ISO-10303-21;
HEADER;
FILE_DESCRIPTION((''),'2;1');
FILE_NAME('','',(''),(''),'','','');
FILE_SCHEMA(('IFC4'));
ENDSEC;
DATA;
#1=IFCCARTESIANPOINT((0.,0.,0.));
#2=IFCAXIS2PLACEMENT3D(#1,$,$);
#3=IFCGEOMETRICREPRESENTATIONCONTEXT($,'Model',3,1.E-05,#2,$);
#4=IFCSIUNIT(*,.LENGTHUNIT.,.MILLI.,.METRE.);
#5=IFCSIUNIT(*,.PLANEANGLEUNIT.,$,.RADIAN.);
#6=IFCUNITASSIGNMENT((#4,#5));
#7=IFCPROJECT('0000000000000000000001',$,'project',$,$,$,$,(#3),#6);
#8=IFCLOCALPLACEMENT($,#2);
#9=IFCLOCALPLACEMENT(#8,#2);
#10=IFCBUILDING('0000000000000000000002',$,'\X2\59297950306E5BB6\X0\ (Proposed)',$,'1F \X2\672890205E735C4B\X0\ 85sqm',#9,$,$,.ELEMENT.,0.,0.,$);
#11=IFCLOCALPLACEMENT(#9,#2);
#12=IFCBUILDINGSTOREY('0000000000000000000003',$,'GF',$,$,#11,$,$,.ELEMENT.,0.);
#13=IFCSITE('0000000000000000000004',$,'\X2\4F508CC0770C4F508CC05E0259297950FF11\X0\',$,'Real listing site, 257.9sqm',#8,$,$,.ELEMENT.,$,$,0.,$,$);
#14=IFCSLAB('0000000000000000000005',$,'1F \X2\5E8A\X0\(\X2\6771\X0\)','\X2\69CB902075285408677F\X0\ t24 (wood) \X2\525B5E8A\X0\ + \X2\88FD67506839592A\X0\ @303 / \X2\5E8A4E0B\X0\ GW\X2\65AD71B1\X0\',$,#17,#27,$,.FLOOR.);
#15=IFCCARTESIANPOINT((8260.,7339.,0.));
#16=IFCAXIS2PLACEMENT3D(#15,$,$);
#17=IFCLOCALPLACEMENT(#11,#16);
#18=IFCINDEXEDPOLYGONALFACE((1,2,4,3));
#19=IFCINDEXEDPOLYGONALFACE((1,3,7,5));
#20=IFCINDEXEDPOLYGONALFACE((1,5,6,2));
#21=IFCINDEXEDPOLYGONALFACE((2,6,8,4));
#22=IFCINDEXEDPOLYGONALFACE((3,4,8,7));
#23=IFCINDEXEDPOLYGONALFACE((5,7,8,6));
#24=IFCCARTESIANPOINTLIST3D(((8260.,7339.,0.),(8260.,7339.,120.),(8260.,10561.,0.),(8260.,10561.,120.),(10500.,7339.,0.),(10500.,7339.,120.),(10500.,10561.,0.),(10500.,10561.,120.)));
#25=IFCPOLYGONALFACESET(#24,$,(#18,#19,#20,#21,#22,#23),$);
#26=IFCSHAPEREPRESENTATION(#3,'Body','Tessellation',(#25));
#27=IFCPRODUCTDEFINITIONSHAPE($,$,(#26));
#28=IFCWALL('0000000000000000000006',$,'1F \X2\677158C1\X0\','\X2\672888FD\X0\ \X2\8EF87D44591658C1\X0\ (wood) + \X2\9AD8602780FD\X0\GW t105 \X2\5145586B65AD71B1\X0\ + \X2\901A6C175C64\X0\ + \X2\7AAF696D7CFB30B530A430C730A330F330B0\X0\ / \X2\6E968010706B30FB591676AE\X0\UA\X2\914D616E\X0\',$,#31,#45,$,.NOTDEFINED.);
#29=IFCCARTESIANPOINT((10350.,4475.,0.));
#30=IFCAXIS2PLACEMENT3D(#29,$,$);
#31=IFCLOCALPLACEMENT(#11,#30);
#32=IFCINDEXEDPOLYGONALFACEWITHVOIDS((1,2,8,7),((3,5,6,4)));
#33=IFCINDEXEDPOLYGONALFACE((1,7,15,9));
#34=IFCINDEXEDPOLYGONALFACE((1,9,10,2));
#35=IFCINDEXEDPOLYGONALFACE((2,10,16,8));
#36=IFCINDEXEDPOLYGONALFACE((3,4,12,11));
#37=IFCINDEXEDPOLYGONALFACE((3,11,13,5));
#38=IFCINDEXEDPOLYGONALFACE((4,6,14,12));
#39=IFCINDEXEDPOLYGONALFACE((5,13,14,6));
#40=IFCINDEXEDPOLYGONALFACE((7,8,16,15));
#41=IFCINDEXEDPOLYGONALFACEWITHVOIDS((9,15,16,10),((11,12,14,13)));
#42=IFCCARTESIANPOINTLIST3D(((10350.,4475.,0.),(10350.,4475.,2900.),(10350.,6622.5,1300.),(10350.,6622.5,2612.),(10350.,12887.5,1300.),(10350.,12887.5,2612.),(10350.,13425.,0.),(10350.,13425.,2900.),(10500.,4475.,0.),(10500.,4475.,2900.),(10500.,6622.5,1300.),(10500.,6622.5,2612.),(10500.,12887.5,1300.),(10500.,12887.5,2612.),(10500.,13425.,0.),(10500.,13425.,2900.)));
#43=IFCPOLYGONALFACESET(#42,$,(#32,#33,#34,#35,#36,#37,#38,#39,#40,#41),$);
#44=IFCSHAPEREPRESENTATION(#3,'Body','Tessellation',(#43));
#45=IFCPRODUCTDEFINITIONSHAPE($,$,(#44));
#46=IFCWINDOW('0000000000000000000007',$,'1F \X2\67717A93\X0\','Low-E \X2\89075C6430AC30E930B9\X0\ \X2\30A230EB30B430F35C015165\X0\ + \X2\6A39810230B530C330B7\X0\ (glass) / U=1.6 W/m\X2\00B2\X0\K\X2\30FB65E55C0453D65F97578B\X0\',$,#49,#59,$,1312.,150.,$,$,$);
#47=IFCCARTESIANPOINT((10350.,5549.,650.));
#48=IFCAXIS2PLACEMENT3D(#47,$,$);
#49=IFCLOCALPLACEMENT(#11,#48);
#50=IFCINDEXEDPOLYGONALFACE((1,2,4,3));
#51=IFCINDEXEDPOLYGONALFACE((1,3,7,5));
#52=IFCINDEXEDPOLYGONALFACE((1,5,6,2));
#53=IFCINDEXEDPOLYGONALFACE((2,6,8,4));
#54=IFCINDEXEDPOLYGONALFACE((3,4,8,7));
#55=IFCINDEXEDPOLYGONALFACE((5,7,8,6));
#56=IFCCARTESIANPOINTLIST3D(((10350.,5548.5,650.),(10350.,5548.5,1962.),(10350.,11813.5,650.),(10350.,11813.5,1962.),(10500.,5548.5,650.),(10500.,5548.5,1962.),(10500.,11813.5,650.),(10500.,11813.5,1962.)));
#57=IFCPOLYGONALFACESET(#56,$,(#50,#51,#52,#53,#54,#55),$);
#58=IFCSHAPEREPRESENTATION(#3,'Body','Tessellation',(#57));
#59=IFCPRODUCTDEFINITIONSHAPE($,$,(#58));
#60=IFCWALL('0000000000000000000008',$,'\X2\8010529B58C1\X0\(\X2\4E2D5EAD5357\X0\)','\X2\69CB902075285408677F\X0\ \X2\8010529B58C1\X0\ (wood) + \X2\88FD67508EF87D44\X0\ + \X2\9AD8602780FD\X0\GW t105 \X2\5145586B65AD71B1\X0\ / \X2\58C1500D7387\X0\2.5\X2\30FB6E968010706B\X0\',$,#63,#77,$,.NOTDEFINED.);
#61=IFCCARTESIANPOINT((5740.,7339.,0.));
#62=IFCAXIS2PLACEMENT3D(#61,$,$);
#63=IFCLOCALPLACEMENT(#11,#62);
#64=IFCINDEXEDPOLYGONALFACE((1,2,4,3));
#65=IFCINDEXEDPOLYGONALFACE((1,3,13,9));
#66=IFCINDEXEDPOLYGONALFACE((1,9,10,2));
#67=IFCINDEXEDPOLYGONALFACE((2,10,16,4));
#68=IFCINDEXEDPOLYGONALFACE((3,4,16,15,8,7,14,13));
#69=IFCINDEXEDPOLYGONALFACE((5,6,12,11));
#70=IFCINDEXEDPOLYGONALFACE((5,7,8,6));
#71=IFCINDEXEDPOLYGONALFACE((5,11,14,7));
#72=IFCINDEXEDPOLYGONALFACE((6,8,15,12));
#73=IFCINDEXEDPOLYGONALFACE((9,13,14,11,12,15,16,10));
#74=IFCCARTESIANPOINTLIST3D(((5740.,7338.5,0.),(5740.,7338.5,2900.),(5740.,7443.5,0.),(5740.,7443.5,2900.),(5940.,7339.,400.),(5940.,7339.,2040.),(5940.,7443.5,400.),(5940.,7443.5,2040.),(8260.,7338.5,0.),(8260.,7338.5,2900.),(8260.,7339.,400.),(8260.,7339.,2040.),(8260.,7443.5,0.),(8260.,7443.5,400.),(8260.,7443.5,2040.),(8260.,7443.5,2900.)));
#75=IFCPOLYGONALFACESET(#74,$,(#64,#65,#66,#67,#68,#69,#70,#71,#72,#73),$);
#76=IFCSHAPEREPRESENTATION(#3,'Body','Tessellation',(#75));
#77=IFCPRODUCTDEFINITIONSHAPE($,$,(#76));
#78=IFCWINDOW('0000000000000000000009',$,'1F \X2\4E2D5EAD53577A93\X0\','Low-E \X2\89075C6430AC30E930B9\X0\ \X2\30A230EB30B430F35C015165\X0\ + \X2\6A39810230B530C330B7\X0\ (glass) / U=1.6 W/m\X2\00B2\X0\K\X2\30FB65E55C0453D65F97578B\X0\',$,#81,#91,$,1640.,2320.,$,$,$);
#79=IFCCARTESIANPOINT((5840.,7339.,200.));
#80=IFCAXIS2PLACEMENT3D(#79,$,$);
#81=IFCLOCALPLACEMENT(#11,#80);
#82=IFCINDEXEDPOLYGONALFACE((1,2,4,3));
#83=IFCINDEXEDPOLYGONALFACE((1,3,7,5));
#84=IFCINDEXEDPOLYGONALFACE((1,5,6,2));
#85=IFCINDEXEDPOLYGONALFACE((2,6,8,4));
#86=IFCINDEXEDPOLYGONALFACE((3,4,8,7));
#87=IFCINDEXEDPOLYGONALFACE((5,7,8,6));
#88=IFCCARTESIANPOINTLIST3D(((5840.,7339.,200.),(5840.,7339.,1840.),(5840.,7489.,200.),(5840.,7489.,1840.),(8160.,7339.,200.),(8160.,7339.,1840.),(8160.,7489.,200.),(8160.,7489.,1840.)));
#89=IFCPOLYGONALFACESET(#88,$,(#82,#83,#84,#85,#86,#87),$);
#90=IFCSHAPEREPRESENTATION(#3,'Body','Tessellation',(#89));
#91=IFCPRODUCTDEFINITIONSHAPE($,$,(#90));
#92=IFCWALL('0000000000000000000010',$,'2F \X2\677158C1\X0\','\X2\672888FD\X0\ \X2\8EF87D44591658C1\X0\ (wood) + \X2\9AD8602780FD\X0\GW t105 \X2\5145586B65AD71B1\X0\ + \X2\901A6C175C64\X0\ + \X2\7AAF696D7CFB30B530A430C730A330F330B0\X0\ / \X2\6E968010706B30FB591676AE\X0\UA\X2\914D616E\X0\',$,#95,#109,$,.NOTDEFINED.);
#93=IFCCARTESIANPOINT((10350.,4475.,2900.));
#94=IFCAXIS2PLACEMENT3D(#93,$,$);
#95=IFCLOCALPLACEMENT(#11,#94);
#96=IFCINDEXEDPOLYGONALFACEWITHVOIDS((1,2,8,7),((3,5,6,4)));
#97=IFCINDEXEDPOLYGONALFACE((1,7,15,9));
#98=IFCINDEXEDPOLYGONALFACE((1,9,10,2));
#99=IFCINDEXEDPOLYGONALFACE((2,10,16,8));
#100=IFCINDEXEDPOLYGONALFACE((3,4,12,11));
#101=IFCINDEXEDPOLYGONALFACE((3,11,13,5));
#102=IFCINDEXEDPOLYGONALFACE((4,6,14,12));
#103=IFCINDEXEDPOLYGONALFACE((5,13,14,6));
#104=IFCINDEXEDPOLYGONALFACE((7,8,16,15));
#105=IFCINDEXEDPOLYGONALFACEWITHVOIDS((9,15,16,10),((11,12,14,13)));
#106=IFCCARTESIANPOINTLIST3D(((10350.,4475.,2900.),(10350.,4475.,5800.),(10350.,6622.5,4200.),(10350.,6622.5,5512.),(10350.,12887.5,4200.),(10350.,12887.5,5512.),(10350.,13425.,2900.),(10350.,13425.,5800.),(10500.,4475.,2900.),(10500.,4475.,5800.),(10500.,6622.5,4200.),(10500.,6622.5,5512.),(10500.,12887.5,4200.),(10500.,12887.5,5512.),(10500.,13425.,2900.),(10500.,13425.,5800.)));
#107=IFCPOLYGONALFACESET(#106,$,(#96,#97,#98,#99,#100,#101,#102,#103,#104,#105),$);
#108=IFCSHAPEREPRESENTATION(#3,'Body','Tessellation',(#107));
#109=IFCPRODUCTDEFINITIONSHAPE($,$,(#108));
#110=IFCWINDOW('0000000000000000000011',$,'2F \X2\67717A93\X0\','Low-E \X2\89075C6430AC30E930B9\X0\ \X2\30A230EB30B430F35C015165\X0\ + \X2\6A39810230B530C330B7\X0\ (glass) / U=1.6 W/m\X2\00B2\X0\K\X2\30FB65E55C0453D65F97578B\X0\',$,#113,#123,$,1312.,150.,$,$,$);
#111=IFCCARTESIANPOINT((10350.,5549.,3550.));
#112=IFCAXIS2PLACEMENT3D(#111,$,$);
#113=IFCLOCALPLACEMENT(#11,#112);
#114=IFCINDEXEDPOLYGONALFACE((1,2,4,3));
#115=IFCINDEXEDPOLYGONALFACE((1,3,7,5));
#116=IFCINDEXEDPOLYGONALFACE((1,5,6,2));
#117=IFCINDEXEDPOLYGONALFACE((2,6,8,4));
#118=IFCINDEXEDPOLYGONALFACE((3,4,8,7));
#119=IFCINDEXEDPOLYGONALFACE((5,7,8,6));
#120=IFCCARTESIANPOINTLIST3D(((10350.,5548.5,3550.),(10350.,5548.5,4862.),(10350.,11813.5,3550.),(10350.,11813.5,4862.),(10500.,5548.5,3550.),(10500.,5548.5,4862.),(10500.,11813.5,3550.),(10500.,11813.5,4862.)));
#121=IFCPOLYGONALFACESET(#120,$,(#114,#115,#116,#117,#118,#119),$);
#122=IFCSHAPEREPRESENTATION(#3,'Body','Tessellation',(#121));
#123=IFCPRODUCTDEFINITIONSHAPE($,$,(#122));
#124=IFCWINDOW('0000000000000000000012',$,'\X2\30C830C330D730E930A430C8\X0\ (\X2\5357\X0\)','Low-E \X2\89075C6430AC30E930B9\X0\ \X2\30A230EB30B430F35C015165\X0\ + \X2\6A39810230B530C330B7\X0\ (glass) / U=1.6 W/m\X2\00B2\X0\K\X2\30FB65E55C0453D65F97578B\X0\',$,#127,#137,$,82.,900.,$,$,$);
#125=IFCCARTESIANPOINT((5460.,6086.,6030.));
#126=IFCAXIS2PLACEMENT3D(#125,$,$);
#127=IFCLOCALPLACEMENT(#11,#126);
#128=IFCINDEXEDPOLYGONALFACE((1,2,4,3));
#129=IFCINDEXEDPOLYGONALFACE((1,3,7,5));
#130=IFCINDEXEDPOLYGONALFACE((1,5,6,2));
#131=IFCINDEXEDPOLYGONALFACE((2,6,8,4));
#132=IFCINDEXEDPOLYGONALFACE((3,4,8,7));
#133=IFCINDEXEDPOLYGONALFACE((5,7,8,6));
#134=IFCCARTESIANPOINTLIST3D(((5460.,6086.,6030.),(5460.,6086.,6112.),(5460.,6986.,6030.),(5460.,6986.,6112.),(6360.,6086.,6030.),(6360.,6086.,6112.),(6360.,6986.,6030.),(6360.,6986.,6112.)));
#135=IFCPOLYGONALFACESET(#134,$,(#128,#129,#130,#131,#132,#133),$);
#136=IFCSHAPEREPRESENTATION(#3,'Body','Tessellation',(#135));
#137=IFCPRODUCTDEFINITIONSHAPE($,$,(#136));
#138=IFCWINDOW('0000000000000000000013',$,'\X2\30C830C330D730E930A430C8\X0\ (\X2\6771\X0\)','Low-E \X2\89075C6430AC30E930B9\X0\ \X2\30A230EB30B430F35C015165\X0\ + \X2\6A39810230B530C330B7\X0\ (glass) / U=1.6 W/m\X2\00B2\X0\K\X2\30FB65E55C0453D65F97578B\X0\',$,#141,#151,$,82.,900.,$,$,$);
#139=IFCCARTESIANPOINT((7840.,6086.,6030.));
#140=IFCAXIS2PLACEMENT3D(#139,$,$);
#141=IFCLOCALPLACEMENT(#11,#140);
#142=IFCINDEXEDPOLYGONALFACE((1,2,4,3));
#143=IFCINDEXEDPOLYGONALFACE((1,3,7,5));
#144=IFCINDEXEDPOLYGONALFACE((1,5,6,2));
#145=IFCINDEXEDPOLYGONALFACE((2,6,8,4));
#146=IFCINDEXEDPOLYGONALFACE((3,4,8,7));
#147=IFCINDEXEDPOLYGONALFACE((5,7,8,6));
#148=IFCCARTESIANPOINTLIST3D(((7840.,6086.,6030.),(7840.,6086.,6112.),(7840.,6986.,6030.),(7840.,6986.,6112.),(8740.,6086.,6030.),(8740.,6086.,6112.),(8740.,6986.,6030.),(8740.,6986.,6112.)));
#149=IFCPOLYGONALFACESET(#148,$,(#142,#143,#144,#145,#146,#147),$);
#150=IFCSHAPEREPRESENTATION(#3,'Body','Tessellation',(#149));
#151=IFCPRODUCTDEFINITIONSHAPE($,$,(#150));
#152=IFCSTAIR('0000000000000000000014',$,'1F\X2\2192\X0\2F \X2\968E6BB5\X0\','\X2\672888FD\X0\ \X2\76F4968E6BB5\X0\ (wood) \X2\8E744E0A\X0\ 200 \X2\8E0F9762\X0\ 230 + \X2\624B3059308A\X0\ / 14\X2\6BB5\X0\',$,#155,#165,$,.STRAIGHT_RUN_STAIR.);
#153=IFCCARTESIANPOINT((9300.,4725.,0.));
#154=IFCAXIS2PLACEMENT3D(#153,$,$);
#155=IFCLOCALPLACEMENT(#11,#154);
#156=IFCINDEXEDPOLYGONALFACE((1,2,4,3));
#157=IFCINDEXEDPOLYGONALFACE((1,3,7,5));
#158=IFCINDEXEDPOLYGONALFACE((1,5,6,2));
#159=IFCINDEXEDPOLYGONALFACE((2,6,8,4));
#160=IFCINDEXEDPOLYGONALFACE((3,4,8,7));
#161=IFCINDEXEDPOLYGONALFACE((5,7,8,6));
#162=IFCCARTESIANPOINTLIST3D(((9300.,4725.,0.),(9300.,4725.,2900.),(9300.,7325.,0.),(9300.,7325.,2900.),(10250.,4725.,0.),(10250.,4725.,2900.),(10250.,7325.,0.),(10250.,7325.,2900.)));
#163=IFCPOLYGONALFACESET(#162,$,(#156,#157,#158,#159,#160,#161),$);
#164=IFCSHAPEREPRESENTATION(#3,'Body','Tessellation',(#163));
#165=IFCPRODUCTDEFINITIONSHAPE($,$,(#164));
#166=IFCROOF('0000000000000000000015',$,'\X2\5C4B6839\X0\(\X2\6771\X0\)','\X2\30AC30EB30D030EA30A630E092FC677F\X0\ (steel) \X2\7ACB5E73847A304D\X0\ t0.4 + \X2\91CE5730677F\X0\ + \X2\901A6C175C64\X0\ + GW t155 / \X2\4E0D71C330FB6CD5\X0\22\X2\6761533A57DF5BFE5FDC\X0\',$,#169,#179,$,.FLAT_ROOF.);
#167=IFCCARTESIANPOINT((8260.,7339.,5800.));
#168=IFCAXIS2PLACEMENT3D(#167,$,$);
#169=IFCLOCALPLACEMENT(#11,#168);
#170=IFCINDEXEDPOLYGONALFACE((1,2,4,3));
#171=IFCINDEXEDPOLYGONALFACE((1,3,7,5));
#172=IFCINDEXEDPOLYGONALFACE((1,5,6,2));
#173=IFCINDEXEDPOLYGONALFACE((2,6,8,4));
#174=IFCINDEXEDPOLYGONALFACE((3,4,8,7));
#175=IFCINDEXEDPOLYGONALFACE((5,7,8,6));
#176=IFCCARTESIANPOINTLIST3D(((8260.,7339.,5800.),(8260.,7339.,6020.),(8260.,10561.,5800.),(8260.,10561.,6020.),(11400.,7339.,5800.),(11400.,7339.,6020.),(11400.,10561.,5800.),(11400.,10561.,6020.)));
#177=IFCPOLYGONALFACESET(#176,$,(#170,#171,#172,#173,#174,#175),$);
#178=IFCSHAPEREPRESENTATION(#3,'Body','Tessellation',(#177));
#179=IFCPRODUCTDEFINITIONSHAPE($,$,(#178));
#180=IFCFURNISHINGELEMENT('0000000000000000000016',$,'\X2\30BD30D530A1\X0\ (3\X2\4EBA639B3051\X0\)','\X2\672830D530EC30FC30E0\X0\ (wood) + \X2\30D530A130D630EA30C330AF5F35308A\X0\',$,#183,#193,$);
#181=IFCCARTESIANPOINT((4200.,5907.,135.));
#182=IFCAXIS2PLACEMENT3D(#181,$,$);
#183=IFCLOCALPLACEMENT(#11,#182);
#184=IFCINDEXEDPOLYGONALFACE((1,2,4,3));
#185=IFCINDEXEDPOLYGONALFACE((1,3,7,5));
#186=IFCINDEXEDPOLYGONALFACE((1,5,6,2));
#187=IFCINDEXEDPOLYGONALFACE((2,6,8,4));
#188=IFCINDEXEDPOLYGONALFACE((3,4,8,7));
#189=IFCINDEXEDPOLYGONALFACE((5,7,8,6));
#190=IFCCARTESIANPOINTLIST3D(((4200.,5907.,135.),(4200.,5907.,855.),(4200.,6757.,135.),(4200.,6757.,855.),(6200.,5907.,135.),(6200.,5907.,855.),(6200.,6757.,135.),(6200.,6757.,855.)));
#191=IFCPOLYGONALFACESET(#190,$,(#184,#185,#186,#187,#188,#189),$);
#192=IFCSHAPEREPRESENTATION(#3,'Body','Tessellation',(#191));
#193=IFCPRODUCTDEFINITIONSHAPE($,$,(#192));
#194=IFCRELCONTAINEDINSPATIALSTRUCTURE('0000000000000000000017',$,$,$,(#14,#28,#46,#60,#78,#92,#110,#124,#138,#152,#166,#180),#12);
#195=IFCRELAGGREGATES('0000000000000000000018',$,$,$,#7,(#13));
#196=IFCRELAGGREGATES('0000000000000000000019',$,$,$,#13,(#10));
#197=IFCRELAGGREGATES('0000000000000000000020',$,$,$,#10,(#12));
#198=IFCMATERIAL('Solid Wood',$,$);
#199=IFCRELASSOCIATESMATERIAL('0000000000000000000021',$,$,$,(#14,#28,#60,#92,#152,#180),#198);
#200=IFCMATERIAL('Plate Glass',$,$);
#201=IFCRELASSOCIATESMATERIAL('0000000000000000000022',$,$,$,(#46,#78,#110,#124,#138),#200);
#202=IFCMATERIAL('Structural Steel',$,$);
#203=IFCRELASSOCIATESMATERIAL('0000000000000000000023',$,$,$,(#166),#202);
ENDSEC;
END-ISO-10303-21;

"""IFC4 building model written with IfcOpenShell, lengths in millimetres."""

from ifc_helpers import new_model, si_unit, frame, frame_2d, origin, place, context, project, spatial, rectangle, extrude, material, element, fill, save


model = new_model("IFC4")

# Units and contexts
model_context = context("Model", 3, precision=1e-05, world=origin())
ifc_project = project(units=[si_unit("LENGTHUNIT", "METRE", prefix="MILLI"), si_unit("PLANEANGLEUNIT", "RADIAN")], contexts=[model_context])

# Site, building, storey
site_placement = place(None, origin())
site = spatial("IfcSite", under=ifc_project, at=site_placement, Name="佐賀県佐賀市天祐１", ObjectType="Real listing site, 257.9sqm", CompositionType="ELEMENT", RefElevation=0.0)
building_placement = place(site_placement, origin())
building = spatial("IfcBuilding", under=site, at=building_placement, Name="天祐の家 (Proposed)", ObjectType="1F 木造平屋 85sqm", CompositionType="ELEMENT", ElevationOfRefHeight=0.0, ElevationOfTerrain=0.0)
storey_placement = place(building_placement, origin())
storey = spatial("IfcBuildingStorey", under=building, at=storey_placement, Name="GF", CompositionType="ELEMENT", Elevation=0.0)

# Slab
ifc_material_1 = material(Name="Solid Wood")
slab_placement = place(storey_placement, frame((8260.0, 7339.0, 0.0)))
element("IfcSlab", 1, at=slab_placement, inside=storey, material=ifc_material_1, Name="1F 床(東)", Description="構造用合板 t24 (wood) 剛床 + 製材根太 @303 / 床下 GW断熱", PredefinedType="FLOOR", context=model_context, shape_type="SweptSolid", body=[
    extrude(rectangle(XDim=2240.0, YDim=3222.0, at=frame_2d((1120.0, 1611.0))), frame((8260.0, 7339.0, 0.0)), (0.0, 0.0, 1.0), 120.0),
])

# Walls, openings, windows
wall_1_placement = place(storey_placement, frame((10350.0, 4475.0, 0.0)))
wall_1 = element("IfcWall", 2, at=wall_1_placement, inside=storey, material=ifc_material_1, Name="1F 東壁", Description="木製 軸組外壁 (wood) + 高性能GW t105 充填断熱 + 通気層 + 窯業系サイディング / 準耐火・外皮UA配慮", PredefinedType="NOTDEFINED", context=model_context, shape_type="SweptSolid", body=[
    extrude(rectangle(XDim=150.0, YDim=8950.0, at=frame_2d((75.0, 4475.0))), frame((10350.0, 4475.0, 0.0)), (0.0, 0.0, 1.0), 2900.0),
])
opening_1_placement = place(storey_placement, frame((10350.0, 5549.0, 650.0)))
opening_1 = element("IfcOpeningElement", 3, at=opening_1_placement, cuts=wall_1, PredefinedType="NOTDEFINED", context=model_context, shape_type="SweptSolid", body=[
    extrude(rectangle(XDim=150.0, YDim=6265.0, at=frame_2d((75.0, 3132.0))), frame((10350.0, 5549.0, 650.0)), (0.0, 0.0, 1.0), 1312.0),
])
ifc_material_2 = material(Name="Plate Glass")
window_1_placement = place(storey_placement, frame((10350.0, 5549.0, 650.0)))
window_1 = element("IfcWindow", 4, at=window_1_placement, inside=storey, material=ifc_material_2, Name="1F 東窓", Description="Low-E 複層ガラス アルゴン封入 + 樹脂サッシ (glass) / U=1.6 W/m²K・日射取得型", OverallHeight=1312.0, OverallWidth=150.0, context=model_context, shape_type="SweptSolid", body=[
    extrude(rectangle(XDim=150.0, YDim=6265.0, at=frame_2d((75.0, 3132.0))), frame((10350.0, 5549.0, 650.0)), (0.0, 0.0, 1.0), 1312.0),
])
fill(opening_1, window_1)
wall_2_placement = place(storey_placement, frame((5740.0, 7339.0, 0.0)))
wall_2 = element("IfcWall", 5, at=wall_2_placement, inside=storey, material=ifc_material_1, Name="耐力壁(中庭南)", Description="構造用合板 耐力壁 (wood) + 製材軸組 + 高性能GW t105 充填断熱 / 壁倍率2.5・準耐火", PredefinedType="NOTDEFINED", context=model_context, shape_type="SweptSolid", body=[
    extrude(rectangle(XDim=2520.0, YDim=105.0, at=frame_2d((1260.0, 52.0))), frame((5740.0, 7339.0, 0.0)), (0.0, 0.0, 1.0), 2900.0),
])
opening_2_placement = place(storey_placement, frame((5840.0, 7339.0, 200.0)))
opening_2 = element("IfcOpeningElement", 6, at=opening_2_placement, cuts=wall_2, PredefinedType="NOTDEFINED", context=model_context, shape_type="SweptSolid", body=[
    extrude(rectangle(XDim=2320.0, YDim=150.0, at=frame_2d((1160.0, 75.0))), frame((5840.0, 7339.0, 200.0)), (0.0, 0.0, 1.0), 1640.0),
])
window_2_placement = place(storey_placement, frame((5840.0, 7339.0, 200.0)))
window_2 = element("IfcWindow", 7, at=window_2_placement, inside=storey, material=ifc_material_2, Name="1F 中庭南窓", Description="Low-E 複層ガラス アルゴン封入 + 樹脂サッシ (glass) / U=1.6 W/m²K・日射取得型", OverallHeight=1640.0, OverallWidth=2320.0, context=model_context, shape_type="SweptSolid", body=[
    extrude(rectangle(XDim=2320.0, YDim=150.0, at=frame_2d((1160.0, 75.0))), frame((5840.0, 7339.0, 200.0)), (0.0, 0.0, 1.0), 1640.0),
])
fill(opening_2, window_2)

# Wall, opening, window
wall_3_placement = place(storey_placement, frame((10350.0, 4475.0, 2900.0)))
wall_3 = element("IfcWall", 8, at=wall_3_placement, inside=storey, material=ifc_material_1, Name="2F 東壁", Description="木製 軸組外壁 (wood) + 高性能GW t105 充填断熱 + 通気層 + 窯業系サイディング / 準耐火・外皮UA配慮", PredefinedType="NOTDEFINED", context=model_context, shape_type="SweptSolid", body=[
    extrude(rectangle(XDim=150.0, YDim=8950.0, at=frame_2d((75.0, 4475.0))), frame((10350.0, 4475.0, 2900.0)), (0.0, 0.0, 1.0), 2900.0),
])
opening_3_placement = place(storey_placement, frame((10350.0, 5549.0, 3550.0)))
opening_3 = element("IfcOpeningElement", 9, at=opening_3_placement, cuts=wall_3, PredefinedType="NOTDEFINED", context=model_context, shape_type="SweptSolid", body=[
    extrude(rectangle(XDim=150.0, YDim=6265.0, at=frame_2d((75.0, 3132.0))), frame((10350.0, 5549.0, 3550.0)), (0.0, 0.0, 1.0), 1312.0),
])
window_3_placement = place(storey_placement, frame((10350.0, 5549.0, 3550.0)))
window_3 = element("IfcWindow", 10, at=window_3_placement, inside=storey, material=ifc_material_2, Name="2F 東窓", Description="Low-E 複層ガラス アルゴン封入 + 樹脂サッシ (glass) / U=1.6 W/m²K・日射取得型", OverallHeight=1312.0, OverallWidth=150.0, context=model_context, shape_type="SweptSolid", body=[
    extrude(rectangle(XDim=150.0, YDim=6265.0, at=frame_2d((75.0, 3132.0))), frame((10350.0, 5549.0, 3550.0)), (0.0, 0.0, 1.0), 1312.0),
])
fill(opening_3, window_3)

# Windows
window_4_placement = place(storey_placement, frame((5460.0, 6086.0, 6030.0)))
element("IfcWindow", 11, at=window_4_placement, inside=storey, material=ifc_material_2, Name="トップライト (南)", Description="Low-E 複層ガラス アルゴン封入 + 樹脂サッシ (glass) / U=1.6 W/m²K・日射取得型", OverallHeight=82.0, OverallWidth=900.0, context=model_context, shape_type="SweptSolid", body=[
    extrude(rectangle(XDim=900.0, YDim=900.0, at=frame_2d((450.0, 450.0))), frame((5460.0, 6086.0, 6030.0)), (0.0, 0.0, 1.0), 82.0),
])
window_5_placement = place(storey_placement, frame((7840.0, 6086.0, 6030.0)))
element("IfcWindow", 12, at=window_5_placement, inside=storey, material=ifc_material_2, Name="トップライト (東)", Description="Low-E 複層ガラス アルゴン封入 + 樹脂サッシ (glass) / U=1.6 W/m²K・日射取得型", OverallHeight=82.0, OverallWidth=900.0, context=model_context, shape_type="SweptSolid", body=[
    extrude(rectangle(XDim=900.0, YDim=900.0, at=frame_2d((450.0, 450.0))), frame((7840.0, 6086.0, 6030.0)), (0.0, 0.0, 1.0), 82.0),
])

# Stair
stair_placement = place(storey_placement, frame((9300.0, 4725.0, 0.0)))
element("IfcStair", 13, at=stair_placement, inside=storey, material=ifc_material_1, Name="1F→2F 階段", Description="木製 直階段 (wood) 蹴上 200 踏面 230 + 手すり / 14段", PredefinedType="STRAIGHT_RUN_STAIR", context=model_context, shape_type="SweptSolid", body=[
    extrude(rectangle(XDim=950.0, YDim=2600.0, at=frame_2d((475.0, 1300.0))), frame((9300.0, 4725.0, 0.0)), (0.0, 0.0, 1.0), 2900.0),
])

# Roof
ifc_material_3 = material(Name="Structural Steel")
roof_placement = place(storey_placement, frame((8260.0, 7339.0, 5800.0)))
element("IfcRoof", 14, at=roof_placement, inside=storey, material=ifc_material_3, Name="屋根(東)", Description="ガルバリウム鋼板 (steel) 立平葺き t0.4 + 野地板 + 通気層 + GW t155 / 不燃・法22条区域対応", PredefinedType="FLAT_ROOF", context=model_context, shape_type="SweptSolid", body=[
    extrude(rectangle(XDim=3140.0, YDim=3222.0, at=frame_2d((1570.0, 1611.0))), frame((8260.0, 7339.0, 5800.0)), (0.0, 0.0, 1.0), 220.0),
])

# Furnishing element
furnishing_1_placement = place(storey_placement, frame((4200.0, 5907.0, 135.0)))
element("IfcFurnishingElement", 15, at=furnishing_1_placement, inside=storey, material=ifc_material_1, Name="ソファ (3人掛け)", Description="木フレーム (wood) + ファブリック張り", context=model_context, shape_type="SweptSolid", body=[
    extrude(rectangle(XDim=2000.0, YDim=850.0, at=frame_2d((1000.0, 425.0))), frame((4200.0, 5907.0, 135.0)), (0.0, 0.0, 1.0), 720.0),
])

save(model, "model.ifc")
